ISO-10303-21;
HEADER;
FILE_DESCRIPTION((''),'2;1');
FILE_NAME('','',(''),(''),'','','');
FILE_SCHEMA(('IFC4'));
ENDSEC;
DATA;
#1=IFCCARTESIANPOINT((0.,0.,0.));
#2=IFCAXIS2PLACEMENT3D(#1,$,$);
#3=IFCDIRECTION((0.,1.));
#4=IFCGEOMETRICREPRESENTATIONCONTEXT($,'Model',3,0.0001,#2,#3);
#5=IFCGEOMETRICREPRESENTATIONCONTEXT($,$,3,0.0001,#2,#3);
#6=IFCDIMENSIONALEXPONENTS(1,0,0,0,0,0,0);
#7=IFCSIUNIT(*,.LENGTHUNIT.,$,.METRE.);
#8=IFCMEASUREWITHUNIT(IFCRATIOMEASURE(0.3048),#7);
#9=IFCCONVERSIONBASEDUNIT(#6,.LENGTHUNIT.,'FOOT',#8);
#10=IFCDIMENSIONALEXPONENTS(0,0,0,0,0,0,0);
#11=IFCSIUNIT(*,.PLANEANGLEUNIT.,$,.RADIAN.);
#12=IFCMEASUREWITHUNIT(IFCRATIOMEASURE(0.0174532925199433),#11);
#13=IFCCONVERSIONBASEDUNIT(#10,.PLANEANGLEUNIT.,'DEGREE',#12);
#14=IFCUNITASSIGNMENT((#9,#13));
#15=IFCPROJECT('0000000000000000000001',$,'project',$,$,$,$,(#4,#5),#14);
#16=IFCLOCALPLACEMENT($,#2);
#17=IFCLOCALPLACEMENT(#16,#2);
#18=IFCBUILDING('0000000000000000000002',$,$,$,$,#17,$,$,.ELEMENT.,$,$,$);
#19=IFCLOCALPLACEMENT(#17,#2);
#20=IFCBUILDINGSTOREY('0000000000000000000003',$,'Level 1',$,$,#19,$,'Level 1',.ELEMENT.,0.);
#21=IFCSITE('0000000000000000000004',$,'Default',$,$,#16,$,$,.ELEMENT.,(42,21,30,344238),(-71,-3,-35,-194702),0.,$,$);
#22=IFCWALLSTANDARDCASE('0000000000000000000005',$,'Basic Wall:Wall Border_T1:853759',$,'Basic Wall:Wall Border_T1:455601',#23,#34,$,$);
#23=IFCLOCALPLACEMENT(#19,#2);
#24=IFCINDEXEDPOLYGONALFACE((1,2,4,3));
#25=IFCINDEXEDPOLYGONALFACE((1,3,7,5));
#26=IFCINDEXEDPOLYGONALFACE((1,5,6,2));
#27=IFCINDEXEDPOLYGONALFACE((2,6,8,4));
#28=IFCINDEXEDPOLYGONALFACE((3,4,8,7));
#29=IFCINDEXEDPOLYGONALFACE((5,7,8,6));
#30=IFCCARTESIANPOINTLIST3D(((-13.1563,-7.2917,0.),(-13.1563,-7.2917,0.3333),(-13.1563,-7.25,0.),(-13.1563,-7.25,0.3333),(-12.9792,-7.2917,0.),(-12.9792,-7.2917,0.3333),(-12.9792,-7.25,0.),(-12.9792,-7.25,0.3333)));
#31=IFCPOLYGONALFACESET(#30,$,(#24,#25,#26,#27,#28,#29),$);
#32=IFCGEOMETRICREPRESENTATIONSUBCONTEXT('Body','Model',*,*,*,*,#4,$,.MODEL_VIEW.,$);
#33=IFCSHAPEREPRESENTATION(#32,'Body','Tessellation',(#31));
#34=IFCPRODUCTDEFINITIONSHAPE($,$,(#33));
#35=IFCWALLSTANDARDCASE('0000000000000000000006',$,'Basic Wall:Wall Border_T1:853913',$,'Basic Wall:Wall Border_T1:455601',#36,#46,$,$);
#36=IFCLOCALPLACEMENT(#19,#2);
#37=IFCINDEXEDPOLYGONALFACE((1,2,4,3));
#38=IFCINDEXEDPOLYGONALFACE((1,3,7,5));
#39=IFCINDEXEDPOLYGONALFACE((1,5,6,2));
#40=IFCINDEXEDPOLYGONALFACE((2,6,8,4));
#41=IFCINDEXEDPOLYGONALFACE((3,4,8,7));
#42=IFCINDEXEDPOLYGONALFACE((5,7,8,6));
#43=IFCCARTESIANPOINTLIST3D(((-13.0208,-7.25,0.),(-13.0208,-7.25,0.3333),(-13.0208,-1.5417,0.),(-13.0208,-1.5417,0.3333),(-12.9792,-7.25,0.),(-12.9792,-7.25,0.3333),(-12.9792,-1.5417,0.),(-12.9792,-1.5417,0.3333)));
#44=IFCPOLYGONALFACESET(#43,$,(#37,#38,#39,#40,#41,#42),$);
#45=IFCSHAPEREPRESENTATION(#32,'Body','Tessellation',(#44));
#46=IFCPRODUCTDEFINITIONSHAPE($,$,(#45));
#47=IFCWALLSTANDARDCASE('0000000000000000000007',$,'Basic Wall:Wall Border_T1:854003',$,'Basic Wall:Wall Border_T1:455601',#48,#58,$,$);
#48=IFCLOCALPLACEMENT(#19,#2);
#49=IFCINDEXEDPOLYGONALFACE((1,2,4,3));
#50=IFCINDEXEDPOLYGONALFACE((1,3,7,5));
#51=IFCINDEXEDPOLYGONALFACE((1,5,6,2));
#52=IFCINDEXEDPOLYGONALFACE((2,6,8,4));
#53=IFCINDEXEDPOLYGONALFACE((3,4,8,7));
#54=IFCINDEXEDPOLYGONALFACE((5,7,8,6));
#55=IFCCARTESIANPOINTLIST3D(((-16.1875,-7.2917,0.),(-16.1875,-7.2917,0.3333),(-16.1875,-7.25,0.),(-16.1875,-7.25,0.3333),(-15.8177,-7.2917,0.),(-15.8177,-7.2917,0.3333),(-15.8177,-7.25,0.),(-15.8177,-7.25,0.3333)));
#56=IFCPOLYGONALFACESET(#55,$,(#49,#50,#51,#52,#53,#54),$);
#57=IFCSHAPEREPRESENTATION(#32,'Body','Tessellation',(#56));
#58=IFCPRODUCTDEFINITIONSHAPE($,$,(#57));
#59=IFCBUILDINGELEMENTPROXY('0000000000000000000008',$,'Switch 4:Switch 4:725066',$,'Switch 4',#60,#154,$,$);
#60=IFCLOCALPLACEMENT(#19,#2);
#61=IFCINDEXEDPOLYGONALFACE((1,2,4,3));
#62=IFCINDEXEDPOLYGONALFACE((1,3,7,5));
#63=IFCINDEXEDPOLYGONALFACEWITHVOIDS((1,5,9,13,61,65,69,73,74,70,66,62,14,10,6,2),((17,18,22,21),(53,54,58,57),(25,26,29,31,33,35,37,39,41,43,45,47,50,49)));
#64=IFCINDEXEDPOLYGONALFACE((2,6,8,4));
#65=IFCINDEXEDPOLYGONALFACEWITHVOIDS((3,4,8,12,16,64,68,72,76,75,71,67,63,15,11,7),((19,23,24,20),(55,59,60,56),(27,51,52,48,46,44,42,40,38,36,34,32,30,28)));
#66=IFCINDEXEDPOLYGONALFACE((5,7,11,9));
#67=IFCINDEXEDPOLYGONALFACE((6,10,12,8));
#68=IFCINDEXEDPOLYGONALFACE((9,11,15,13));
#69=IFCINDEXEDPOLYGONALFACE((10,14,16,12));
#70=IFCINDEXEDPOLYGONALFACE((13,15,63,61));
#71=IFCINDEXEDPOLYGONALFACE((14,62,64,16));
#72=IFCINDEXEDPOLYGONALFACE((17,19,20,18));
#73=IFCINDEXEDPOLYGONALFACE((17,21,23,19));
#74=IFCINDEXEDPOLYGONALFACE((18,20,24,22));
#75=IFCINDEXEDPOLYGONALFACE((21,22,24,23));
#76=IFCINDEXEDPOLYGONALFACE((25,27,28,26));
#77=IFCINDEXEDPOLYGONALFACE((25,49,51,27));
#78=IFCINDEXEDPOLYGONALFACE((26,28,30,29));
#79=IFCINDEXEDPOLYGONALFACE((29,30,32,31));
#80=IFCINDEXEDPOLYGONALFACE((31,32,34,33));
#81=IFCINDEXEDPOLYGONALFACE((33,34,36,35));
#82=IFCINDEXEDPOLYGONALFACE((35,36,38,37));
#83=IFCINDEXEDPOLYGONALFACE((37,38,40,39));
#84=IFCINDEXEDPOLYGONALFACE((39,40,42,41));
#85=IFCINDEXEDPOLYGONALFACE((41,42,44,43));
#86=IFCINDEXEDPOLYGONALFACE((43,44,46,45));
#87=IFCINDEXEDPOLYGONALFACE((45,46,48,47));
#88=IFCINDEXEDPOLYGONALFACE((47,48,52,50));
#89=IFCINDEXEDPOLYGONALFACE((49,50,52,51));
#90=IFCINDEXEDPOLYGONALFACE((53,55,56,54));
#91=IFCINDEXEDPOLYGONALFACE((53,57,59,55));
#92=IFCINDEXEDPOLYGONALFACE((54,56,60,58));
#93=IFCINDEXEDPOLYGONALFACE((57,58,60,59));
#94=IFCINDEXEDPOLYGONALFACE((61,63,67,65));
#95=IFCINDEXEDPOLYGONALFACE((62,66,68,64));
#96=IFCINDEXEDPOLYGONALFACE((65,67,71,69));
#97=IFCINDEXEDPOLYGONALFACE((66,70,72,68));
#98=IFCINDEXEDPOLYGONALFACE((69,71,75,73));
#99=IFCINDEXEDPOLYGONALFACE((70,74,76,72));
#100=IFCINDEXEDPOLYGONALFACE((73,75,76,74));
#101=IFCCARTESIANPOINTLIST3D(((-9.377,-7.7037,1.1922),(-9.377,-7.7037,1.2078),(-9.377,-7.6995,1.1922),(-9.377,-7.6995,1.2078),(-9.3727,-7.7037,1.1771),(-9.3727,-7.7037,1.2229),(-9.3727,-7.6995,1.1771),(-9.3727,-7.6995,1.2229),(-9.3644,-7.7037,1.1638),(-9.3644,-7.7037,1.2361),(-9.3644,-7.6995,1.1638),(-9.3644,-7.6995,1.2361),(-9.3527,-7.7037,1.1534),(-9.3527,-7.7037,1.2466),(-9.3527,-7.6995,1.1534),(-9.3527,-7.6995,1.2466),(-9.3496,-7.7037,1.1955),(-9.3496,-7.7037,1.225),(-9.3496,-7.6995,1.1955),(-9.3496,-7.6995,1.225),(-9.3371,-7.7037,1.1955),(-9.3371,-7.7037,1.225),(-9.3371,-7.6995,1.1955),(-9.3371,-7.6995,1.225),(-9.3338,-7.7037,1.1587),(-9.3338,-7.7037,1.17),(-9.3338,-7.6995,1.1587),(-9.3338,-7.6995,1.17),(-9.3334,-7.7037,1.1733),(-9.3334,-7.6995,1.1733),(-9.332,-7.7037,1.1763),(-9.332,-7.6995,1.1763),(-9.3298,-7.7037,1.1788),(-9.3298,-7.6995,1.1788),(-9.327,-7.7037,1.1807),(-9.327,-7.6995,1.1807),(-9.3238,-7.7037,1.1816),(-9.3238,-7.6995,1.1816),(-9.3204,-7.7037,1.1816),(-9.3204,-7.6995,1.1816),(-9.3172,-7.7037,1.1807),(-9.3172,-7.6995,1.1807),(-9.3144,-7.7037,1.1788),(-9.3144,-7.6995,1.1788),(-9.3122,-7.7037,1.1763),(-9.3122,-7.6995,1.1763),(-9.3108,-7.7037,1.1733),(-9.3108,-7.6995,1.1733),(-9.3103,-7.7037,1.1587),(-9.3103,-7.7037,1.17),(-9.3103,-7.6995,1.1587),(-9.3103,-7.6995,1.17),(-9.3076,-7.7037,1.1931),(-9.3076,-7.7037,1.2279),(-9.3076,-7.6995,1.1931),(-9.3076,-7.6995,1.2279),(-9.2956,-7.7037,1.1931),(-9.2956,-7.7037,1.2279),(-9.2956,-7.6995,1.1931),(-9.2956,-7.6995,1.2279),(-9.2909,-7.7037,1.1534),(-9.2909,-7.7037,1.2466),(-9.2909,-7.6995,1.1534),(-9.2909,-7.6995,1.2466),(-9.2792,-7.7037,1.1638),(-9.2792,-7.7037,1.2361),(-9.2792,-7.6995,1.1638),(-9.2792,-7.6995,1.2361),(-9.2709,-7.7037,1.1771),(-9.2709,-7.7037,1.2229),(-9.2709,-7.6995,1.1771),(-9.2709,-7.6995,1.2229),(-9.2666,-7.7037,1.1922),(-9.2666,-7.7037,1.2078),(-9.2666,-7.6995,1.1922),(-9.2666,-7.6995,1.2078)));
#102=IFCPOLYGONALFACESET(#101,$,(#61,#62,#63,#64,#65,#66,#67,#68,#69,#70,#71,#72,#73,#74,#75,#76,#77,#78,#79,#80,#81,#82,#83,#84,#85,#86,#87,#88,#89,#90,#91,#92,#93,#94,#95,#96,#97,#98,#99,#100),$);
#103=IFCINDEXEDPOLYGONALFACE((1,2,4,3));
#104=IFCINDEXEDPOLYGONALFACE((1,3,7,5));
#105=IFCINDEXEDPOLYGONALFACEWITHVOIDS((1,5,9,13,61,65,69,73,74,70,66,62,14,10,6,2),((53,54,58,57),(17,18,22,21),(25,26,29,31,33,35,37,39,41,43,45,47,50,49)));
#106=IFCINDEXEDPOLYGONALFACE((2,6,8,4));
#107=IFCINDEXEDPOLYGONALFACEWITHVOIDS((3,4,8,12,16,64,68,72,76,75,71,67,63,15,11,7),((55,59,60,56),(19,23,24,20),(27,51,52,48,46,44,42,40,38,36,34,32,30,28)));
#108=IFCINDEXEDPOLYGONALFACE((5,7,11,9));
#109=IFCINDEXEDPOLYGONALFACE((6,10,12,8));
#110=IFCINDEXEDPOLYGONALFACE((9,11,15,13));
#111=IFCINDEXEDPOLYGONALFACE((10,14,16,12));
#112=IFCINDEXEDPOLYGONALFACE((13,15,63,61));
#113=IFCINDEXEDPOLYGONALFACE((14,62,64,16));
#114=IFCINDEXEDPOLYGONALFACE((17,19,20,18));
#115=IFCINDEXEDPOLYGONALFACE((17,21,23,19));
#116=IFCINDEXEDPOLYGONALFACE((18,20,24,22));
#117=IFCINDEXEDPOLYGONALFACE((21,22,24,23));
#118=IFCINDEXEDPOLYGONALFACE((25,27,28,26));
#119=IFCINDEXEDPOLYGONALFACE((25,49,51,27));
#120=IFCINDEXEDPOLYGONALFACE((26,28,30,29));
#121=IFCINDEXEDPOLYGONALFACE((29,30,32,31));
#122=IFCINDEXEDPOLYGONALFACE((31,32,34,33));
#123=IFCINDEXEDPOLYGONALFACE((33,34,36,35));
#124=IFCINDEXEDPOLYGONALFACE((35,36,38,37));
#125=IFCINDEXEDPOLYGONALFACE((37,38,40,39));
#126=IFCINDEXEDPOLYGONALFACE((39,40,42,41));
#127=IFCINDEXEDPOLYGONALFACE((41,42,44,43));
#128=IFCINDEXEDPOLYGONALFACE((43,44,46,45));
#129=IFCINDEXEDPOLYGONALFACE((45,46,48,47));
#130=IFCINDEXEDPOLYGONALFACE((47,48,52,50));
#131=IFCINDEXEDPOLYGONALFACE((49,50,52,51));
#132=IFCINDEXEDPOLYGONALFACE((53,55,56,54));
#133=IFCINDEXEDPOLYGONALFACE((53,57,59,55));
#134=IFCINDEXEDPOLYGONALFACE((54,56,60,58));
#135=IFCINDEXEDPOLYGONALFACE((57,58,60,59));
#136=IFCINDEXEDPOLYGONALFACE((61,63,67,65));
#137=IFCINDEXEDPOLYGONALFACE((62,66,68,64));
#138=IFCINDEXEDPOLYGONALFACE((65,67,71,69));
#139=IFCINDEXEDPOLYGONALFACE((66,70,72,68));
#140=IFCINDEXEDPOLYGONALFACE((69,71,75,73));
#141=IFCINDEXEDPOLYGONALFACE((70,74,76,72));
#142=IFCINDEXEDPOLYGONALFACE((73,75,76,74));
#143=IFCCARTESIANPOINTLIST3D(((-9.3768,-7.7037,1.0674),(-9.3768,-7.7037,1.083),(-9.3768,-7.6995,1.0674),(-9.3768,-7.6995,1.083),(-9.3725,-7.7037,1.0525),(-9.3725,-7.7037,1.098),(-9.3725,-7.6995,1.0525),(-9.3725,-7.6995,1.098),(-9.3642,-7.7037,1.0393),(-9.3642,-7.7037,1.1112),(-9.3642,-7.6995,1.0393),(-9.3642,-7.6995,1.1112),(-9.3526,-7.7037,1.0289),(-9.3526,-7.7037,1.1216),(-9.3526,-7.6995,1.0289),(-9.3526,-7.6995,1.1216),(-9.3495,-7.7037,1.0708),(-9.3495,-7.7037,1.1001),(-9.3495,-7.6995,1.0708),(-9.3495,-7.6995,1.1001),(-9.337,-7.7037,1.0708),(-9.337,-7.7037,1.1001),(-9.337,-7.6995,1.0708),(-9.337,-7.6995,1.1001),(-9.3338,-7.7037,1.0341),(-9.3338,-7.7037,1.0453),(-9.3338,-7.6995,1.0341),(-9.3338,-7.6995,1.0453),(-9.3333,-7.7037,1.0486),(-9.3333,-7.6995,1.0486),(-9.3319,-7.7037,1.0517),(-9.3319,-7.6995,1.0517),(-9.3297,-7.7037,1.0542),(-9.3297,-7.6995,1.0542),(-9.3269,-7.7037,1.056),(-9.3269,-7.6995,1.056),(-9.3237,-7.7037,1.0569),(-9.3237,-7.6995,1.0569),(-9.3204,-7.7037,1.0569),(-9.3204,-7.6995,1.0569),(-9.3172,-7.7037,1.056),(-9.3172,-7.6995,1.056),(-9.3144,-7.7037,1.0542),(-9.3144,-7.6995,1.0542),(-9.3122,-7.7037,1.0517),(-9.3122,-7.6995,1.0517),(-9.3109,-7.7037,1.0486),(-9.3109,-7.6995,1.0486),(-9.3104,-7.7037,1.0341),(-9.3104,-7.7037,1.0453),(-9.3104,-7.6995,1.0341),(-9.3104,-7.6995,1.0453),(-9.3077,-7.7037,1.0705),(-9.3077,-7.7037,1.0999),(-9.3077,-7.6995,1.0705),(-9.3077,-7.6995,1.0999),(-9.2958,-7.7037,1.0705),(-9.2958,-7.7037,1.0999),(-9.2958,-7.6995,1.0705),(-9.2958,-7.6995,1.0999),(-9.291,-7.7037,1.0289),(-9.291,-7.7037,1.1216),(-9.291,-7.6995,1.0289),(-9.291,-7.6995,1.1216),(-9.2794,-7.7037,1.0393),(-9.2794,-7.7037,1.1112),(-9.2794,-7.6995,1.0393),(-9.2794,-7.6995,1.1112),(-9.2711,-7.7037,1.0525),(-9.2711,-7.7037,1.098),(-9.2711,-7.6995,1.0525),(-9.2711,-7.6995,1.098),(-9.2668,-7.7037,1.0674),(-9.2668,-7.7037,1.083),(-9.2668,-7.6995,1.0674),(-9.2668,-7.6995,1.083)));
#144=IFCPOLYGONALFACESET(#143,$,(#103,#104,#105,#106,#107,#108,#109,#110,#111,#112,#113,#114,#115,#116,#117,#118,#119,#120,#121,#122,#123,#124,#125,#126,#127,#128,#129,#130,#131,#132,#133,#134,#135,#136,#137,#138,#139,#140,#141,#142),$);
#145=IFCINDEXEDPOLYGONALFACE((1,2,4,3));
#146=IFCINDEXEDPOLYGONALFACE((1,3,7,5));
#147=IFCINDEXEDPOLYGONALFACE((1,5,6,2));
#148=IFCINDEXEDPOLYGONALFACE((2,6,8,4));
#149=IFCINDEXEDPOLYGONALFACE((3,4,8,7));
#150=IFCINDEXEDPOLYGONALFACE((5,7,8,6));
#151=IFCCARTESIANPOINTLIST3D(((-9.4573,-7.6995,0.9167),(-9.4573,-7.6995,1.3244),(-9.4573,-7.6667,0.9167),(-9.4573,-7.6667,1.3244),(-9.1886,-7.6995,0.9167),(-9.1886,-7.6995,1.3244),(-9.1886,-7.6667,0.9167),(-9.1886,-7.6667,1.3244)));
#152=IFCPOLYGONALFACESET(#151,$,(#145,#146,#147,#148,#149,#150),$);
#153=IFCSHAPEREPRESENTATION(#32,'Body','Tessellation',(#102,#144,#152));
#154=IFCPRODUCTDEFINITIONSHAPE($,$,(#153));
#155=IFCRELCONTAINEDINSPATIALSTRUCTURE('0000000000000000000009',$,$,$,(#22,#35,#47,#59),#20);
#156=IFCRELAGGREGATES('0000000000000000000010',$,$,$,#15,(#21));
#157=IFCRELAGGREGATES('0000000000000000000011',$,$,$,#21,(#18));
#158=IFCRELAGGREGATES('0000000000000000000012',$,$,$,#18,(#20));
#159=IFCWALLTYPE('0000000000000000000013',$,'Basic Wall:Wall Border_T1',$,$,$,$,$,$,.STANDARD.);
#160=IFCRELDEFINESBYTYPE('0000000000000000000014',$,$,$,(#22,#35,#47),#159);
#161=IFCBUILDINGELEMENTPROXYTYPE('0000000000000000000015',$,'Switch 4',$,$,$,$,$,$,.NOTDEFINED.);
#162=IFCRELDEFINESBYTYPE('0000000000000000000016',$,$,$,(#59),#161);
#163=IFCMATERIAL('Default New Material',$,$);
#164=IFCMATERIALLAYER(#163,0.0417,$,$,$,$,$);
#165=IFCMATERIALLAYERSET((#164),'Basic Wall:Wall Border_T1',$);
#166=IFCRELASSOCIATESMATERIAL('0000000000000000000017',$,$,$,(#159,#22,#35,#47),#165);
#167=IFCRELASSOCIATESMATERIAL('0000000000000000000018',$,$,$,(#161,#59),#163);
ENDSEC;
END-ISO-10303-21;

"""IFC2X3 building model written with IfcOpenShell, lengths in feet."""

from ifc_helpers import new_model, entity, si_unit, converted_unit, direction, frame, frame_2d, origin, origin_2d_with_axis, place, context, subcontext, project, spatial, polyline, circle_curve, parameter, trimmed, segment, composite_curve, rectangle, outline, extrude, source, transform, mapped, material, layer, layer_set, layer_usage, type_object, type_shapes, element, save


model = new_model("IFC2X3")

# Units and contexts
model_context = context("Model", 3, precision=0.0001, world=origin(), true_north=direction((0.0, 1.0)))
context_of_model = context(None, 3, precision=0.0001, world=origin(), true_north=direction((0.0, 1.0)))
body_context = subcontext(model_context, "Body", "Model", "MODEL_VIEW")
ifc_project = project(units=[converted_unit("LENGTHUNIT", "FOOT", entity("IfcRatioMeasure", 0.3048), si_unit("LENGTHUNIT", "METRE"), dimensions=[1, 0, 0, 0, 0, 0, 0]), converted_unit("PLANEANGLEUNIT", "DEGREE", entity("IfcRatioMeasure", 0.0174532925199433), si_unit("PLANEANGLEUNIT", "RADIAN"), dimensions=[0, 0, 0, 0, 0, 0, 0])], contexts=[model_context, context_of_model])

# Site, building, storey
site_placement = place(None, origin())
site = spatial("IfcSite", under=ifc_project, at=site_placement, Name="Default", CompositionType="ELEMENT", RefLatitude=(42, 21, 30, 344238), RefLongitude=(-71, -3, -35, -194702), RefElevation=0.0)
building_placement = place(site_placement, origin())
building = spatial("IfcBuilding", under=site, at=building_placement, CompositionType="ELEMENT")
storey_placement = place(building_placement, origin())
storey = spatial("IfcBuildingStorey", under=building, at=storey_placement, Name="Level 1", LongName="Level 1", CompositionType="ELEMENT", Elevation=0.0)

# Shared definitions
ifc_material_1 = material(Name="Default New Material")

# Walls
ifc_layer_1 = layer(ifc_material_1, 0.0417)
ifc_layer_set_1 = layer_set([ifc_layer_1], Name="Basic Wall:Wall Border_T1")
wall_type_1 = type_object("IfcWallType", Name="Basic Wall:Wall Border_T1", PredefinedType="STANDARD", material=ifc_layer_set_1)
ifc_layer_usage_1 = layer_usage(ifc_layer_set_1, "AXIS2", "NEGATIVE", 0.0208)
wall_1_placement = place(storey_placement, frame((-13.1562, -7.2708, 0.0)))
element("IfcWallStandardCase", 1, at=wall_1_placement, inside=storey, type_object=wall_type_1, material=ifc_layer_usage_1, Name="Basic Wall:Wall Border_T1:853759", ObjectType="Basic Wall:Wall Border_T1:455601", context=body_context, shape_type="SweptSolid", body=[
    extrude(rectangle(XDim=0.1771, YDim=0.0417, at=frame_2d((0.0885, 0.0), x_axis=(-1.0, 0.0))), origin(), (0.0, 0.0, 1.0), 0.3333),
])
ifc_layer_usage_2 = layer_usage(ifc_layer_set_1, "AXIS2", "NEGATIVE", 0.0208)
wall_2_placement = place(storey_placement, frame((-13.0, -7.25, 0.0), z_axis=(0.0, 0.0, 1.0), x_axis=(0.0, 1.0, 0.0)))
element("IfcWallStandardCase", 2, at=wall_2_placement, inside=storey, type_object=wall_type_1, material=ifc_layer_usage_2, Name="Basic Wall:Wall Border_T1:853913", ObjectType="Basic Wall:Wall Border_T1:455601", context=body_context, shape_type="SweptSolid", body=[
    extrude(rectangle(XDim=5.7083, YDim=0.0417, at=frame_2d((2.8542, 0.0), x_axis=(-1.0, 0.0))), origin(), (0.0, 0.0, 1.0), 0.3333),
])
ifc_layer_usage_3 = layer_usage(ifc_layer_set_1, "AXIS2", "POSITIVE", -0.0208)
wall_3_placement = place(storey_placement, frame((-15.8177, -7.2708, 0.0), z_axis=(0.0, 0.0, 1.0), x_axis=(-1.0, 0.0, 0.0)))
element("IfcWallStandardCase", 3, at=wall_3_placement, inside=storey, type_object=wall_type_1, material=ifc_layer_usage_3, Name="Basic Wall:Wall Border_T1:854003", ObjectType="Basic Wall:Wall Border_T1:455601", context=body_context, shape_type="SweptSolid", body=[
    extrude(rectangle(XDim=0.3698, YDim=0.0417, at=frame_2d((0.1849, 0.0), x_axis=(-1.0, 0.0))), origin(), (0.0, 0.0, 1.0), 0.3333),
])

# Building element proxy
building_element_proxy_type_1 = type_object("IfcBuildingElementProxyType", Name="Switch 4", PredefinedType="NOTDEFINED", material=ifc_material_1)
shared_shape_1 = source(origin(), body_context, "Body", "SweptSolid", [
    extrude(outline(composite_curve([segment(polyline([(-0.0309, -0.0466), (0.0309, -0.0466)]), True, "CONTINUOUS"), segment(trimmed(circle_curve(frame_2d((-0.0003, 0.0), x_axis=(-1.0, 0.0)), 0.0561), [parameter(123.794741)], [parameter(236.205259)], True, "PARAMETER"), True, "CONTINUOUS"), segment(polyline([(0.0309, 0.0466), (-0.0309, 0.0466)]), True, "CONTINUOUS"), segment(trimmed(circle_curve(frame_2d((0.0003, 0.0), x_axis=(1.0, 0.0)), 0.0561), [parameter(123.794741)], [parameter(236.205259)], True, "PARAMETER"), True, "CONTINUOUS")], self_intersect=False), holes=[polyline([(0.0142, 0.0279), (0.0262, 0.0279), (0.0262, -0.0069), (0.0142, -0.0069), (0.0142, 0.0279)]), polyline([(-0.0153, 0.025), (-0.0153, -0.0045), (-0.0278, -0.0045), (-0.0278, 0.025), (-0.0153, 0.025)]), composite_curve([segment(polyline([(-0.012, -0.0413), (-0.012, -0.03)]), True, "CONTINUOUS"), segment(trimmed(circle_curve(frame_2d((-0.0003, -0.03), x_axis=(-1.0, 0.0)), 0.0117), [parameter(180.0)], [parameter(0.0)], True, "PARAMETER"), False, "CONTINUOUS"), segment(polyline([(0.0115, -0.03), (0.0115, -0.0413)]), True, "CONTINUOUS"), segment(polyline([(0.0115, -0.0413), (-0.012, -0.0413)]), True, "CONTINUOUS")], self_intersect=False)]), frame((-0.0011, 0.0328, 0.2833), z_axis=(0.0, 1.0, 0.0), x_axis=(-1.0, 0.0, 0.0)), (0.0, 0.0, 1.0), 0.0042),
    extrude(outline(composite_curve([segment(polyline([(-0.0308, -0.0464), (0.0308, -0.0464)]), True, "CONTINUOUS"), segment(trimmed(circle_curve(frame_2d((-0.0003, 0.0), x_axis=(-1.0, 0.0)), 0.0558), [parameter(123.794741)], [parameter(236.205259)], True, "PARAMETER"), True, "CONTINUOUS"), segment(polyline([(0.0308, 0.0464), (-0.0308, 0.0464)]), True, "CONTINUOUS"), segment(trimmed(circle_curve(frame_2d((0.0003, 0.0), x_axis=(1.0, 0.0)), 0.0558), [parameter(123.794741)], [parameter(236.205259)], True, "PARAMETER"), True, "CONTINUOUS")], self_intersect=False), holes=[polyline([(0.0141, 0.0247), (0.026, 0.0247), (0.026, -0.0047), (0.0141, -0.0047), (0.0141, 0.0247)]), polyline([(-0.0152, 0.0249), (-0.0152, -0.0045), (-0.0277, -0.0045), (-0.0277, 0.0249), (-0.0152, 0.0249)]), composite_curve([segment(polyline([(-0.012, -0.0411), (-0.012, -0.0299)]), True, "CONTINUOUS"), segment(trimmed(circle_curve(frame_2d((-0.0003, -0.0299), x_axis=(-1.0, 0.0)), 0.0117), [parameter(180.0)], [parameter(0.0)], True, "PARAMETER"), False, "CONTINUOUS"), segment(polyline([(0.0114, -0.0299), (0.0114, -0.0411)]), True, "CONTINUOUS"), segment(polyline([(0.0114, -0.0411), (-0.012, -0.0411)]), True, "CONTINUOUS")], self_intersect=False)]), frame((-0.0011, 0.0328, 0.1586), z_axis=(0.0, 1.0, 0.0), x_axis=(-1.0, 0.0, 0.0)), (0.0, 0.0, 1.0), 0.0042),
    extrude(rectangle(XDim=0.0328, YDim=0.2687, at=origin_2d_with_axis()), frame((0.0, 0.0164, 0.0), z_axis=(0.0, 0.0, 1.0), x_axis=(0.0, -1.0, 0.0)), (0.0, 0.0, 1.0), 0.4078),
])
type_shapes(building_element_proxy_type_1, [shared_shape_1])
proxy_1_placement = place(storey_placement, frame((-9.3229, -7.6667, 0.9167), z_axis=(0.0, 0.0, 1.0), x_axis=(-1.0, 0.0, 0.0)))
element("IfcBuildingElementProxy", 4, at=proxy_1_placement, inside=storey, type_object=building_element_proxy_type_1, material=ifc_material_1, Name="Switch 4:Switch 4:725066", ObjectType="Switch 4", context=body_context, shape_type="MappedRepresentation", body=[
    mapped(shared_shape_1, transform((0.0, 0.0, 0.0), scale=1.0)),
])

save(model, "model.ifc")
